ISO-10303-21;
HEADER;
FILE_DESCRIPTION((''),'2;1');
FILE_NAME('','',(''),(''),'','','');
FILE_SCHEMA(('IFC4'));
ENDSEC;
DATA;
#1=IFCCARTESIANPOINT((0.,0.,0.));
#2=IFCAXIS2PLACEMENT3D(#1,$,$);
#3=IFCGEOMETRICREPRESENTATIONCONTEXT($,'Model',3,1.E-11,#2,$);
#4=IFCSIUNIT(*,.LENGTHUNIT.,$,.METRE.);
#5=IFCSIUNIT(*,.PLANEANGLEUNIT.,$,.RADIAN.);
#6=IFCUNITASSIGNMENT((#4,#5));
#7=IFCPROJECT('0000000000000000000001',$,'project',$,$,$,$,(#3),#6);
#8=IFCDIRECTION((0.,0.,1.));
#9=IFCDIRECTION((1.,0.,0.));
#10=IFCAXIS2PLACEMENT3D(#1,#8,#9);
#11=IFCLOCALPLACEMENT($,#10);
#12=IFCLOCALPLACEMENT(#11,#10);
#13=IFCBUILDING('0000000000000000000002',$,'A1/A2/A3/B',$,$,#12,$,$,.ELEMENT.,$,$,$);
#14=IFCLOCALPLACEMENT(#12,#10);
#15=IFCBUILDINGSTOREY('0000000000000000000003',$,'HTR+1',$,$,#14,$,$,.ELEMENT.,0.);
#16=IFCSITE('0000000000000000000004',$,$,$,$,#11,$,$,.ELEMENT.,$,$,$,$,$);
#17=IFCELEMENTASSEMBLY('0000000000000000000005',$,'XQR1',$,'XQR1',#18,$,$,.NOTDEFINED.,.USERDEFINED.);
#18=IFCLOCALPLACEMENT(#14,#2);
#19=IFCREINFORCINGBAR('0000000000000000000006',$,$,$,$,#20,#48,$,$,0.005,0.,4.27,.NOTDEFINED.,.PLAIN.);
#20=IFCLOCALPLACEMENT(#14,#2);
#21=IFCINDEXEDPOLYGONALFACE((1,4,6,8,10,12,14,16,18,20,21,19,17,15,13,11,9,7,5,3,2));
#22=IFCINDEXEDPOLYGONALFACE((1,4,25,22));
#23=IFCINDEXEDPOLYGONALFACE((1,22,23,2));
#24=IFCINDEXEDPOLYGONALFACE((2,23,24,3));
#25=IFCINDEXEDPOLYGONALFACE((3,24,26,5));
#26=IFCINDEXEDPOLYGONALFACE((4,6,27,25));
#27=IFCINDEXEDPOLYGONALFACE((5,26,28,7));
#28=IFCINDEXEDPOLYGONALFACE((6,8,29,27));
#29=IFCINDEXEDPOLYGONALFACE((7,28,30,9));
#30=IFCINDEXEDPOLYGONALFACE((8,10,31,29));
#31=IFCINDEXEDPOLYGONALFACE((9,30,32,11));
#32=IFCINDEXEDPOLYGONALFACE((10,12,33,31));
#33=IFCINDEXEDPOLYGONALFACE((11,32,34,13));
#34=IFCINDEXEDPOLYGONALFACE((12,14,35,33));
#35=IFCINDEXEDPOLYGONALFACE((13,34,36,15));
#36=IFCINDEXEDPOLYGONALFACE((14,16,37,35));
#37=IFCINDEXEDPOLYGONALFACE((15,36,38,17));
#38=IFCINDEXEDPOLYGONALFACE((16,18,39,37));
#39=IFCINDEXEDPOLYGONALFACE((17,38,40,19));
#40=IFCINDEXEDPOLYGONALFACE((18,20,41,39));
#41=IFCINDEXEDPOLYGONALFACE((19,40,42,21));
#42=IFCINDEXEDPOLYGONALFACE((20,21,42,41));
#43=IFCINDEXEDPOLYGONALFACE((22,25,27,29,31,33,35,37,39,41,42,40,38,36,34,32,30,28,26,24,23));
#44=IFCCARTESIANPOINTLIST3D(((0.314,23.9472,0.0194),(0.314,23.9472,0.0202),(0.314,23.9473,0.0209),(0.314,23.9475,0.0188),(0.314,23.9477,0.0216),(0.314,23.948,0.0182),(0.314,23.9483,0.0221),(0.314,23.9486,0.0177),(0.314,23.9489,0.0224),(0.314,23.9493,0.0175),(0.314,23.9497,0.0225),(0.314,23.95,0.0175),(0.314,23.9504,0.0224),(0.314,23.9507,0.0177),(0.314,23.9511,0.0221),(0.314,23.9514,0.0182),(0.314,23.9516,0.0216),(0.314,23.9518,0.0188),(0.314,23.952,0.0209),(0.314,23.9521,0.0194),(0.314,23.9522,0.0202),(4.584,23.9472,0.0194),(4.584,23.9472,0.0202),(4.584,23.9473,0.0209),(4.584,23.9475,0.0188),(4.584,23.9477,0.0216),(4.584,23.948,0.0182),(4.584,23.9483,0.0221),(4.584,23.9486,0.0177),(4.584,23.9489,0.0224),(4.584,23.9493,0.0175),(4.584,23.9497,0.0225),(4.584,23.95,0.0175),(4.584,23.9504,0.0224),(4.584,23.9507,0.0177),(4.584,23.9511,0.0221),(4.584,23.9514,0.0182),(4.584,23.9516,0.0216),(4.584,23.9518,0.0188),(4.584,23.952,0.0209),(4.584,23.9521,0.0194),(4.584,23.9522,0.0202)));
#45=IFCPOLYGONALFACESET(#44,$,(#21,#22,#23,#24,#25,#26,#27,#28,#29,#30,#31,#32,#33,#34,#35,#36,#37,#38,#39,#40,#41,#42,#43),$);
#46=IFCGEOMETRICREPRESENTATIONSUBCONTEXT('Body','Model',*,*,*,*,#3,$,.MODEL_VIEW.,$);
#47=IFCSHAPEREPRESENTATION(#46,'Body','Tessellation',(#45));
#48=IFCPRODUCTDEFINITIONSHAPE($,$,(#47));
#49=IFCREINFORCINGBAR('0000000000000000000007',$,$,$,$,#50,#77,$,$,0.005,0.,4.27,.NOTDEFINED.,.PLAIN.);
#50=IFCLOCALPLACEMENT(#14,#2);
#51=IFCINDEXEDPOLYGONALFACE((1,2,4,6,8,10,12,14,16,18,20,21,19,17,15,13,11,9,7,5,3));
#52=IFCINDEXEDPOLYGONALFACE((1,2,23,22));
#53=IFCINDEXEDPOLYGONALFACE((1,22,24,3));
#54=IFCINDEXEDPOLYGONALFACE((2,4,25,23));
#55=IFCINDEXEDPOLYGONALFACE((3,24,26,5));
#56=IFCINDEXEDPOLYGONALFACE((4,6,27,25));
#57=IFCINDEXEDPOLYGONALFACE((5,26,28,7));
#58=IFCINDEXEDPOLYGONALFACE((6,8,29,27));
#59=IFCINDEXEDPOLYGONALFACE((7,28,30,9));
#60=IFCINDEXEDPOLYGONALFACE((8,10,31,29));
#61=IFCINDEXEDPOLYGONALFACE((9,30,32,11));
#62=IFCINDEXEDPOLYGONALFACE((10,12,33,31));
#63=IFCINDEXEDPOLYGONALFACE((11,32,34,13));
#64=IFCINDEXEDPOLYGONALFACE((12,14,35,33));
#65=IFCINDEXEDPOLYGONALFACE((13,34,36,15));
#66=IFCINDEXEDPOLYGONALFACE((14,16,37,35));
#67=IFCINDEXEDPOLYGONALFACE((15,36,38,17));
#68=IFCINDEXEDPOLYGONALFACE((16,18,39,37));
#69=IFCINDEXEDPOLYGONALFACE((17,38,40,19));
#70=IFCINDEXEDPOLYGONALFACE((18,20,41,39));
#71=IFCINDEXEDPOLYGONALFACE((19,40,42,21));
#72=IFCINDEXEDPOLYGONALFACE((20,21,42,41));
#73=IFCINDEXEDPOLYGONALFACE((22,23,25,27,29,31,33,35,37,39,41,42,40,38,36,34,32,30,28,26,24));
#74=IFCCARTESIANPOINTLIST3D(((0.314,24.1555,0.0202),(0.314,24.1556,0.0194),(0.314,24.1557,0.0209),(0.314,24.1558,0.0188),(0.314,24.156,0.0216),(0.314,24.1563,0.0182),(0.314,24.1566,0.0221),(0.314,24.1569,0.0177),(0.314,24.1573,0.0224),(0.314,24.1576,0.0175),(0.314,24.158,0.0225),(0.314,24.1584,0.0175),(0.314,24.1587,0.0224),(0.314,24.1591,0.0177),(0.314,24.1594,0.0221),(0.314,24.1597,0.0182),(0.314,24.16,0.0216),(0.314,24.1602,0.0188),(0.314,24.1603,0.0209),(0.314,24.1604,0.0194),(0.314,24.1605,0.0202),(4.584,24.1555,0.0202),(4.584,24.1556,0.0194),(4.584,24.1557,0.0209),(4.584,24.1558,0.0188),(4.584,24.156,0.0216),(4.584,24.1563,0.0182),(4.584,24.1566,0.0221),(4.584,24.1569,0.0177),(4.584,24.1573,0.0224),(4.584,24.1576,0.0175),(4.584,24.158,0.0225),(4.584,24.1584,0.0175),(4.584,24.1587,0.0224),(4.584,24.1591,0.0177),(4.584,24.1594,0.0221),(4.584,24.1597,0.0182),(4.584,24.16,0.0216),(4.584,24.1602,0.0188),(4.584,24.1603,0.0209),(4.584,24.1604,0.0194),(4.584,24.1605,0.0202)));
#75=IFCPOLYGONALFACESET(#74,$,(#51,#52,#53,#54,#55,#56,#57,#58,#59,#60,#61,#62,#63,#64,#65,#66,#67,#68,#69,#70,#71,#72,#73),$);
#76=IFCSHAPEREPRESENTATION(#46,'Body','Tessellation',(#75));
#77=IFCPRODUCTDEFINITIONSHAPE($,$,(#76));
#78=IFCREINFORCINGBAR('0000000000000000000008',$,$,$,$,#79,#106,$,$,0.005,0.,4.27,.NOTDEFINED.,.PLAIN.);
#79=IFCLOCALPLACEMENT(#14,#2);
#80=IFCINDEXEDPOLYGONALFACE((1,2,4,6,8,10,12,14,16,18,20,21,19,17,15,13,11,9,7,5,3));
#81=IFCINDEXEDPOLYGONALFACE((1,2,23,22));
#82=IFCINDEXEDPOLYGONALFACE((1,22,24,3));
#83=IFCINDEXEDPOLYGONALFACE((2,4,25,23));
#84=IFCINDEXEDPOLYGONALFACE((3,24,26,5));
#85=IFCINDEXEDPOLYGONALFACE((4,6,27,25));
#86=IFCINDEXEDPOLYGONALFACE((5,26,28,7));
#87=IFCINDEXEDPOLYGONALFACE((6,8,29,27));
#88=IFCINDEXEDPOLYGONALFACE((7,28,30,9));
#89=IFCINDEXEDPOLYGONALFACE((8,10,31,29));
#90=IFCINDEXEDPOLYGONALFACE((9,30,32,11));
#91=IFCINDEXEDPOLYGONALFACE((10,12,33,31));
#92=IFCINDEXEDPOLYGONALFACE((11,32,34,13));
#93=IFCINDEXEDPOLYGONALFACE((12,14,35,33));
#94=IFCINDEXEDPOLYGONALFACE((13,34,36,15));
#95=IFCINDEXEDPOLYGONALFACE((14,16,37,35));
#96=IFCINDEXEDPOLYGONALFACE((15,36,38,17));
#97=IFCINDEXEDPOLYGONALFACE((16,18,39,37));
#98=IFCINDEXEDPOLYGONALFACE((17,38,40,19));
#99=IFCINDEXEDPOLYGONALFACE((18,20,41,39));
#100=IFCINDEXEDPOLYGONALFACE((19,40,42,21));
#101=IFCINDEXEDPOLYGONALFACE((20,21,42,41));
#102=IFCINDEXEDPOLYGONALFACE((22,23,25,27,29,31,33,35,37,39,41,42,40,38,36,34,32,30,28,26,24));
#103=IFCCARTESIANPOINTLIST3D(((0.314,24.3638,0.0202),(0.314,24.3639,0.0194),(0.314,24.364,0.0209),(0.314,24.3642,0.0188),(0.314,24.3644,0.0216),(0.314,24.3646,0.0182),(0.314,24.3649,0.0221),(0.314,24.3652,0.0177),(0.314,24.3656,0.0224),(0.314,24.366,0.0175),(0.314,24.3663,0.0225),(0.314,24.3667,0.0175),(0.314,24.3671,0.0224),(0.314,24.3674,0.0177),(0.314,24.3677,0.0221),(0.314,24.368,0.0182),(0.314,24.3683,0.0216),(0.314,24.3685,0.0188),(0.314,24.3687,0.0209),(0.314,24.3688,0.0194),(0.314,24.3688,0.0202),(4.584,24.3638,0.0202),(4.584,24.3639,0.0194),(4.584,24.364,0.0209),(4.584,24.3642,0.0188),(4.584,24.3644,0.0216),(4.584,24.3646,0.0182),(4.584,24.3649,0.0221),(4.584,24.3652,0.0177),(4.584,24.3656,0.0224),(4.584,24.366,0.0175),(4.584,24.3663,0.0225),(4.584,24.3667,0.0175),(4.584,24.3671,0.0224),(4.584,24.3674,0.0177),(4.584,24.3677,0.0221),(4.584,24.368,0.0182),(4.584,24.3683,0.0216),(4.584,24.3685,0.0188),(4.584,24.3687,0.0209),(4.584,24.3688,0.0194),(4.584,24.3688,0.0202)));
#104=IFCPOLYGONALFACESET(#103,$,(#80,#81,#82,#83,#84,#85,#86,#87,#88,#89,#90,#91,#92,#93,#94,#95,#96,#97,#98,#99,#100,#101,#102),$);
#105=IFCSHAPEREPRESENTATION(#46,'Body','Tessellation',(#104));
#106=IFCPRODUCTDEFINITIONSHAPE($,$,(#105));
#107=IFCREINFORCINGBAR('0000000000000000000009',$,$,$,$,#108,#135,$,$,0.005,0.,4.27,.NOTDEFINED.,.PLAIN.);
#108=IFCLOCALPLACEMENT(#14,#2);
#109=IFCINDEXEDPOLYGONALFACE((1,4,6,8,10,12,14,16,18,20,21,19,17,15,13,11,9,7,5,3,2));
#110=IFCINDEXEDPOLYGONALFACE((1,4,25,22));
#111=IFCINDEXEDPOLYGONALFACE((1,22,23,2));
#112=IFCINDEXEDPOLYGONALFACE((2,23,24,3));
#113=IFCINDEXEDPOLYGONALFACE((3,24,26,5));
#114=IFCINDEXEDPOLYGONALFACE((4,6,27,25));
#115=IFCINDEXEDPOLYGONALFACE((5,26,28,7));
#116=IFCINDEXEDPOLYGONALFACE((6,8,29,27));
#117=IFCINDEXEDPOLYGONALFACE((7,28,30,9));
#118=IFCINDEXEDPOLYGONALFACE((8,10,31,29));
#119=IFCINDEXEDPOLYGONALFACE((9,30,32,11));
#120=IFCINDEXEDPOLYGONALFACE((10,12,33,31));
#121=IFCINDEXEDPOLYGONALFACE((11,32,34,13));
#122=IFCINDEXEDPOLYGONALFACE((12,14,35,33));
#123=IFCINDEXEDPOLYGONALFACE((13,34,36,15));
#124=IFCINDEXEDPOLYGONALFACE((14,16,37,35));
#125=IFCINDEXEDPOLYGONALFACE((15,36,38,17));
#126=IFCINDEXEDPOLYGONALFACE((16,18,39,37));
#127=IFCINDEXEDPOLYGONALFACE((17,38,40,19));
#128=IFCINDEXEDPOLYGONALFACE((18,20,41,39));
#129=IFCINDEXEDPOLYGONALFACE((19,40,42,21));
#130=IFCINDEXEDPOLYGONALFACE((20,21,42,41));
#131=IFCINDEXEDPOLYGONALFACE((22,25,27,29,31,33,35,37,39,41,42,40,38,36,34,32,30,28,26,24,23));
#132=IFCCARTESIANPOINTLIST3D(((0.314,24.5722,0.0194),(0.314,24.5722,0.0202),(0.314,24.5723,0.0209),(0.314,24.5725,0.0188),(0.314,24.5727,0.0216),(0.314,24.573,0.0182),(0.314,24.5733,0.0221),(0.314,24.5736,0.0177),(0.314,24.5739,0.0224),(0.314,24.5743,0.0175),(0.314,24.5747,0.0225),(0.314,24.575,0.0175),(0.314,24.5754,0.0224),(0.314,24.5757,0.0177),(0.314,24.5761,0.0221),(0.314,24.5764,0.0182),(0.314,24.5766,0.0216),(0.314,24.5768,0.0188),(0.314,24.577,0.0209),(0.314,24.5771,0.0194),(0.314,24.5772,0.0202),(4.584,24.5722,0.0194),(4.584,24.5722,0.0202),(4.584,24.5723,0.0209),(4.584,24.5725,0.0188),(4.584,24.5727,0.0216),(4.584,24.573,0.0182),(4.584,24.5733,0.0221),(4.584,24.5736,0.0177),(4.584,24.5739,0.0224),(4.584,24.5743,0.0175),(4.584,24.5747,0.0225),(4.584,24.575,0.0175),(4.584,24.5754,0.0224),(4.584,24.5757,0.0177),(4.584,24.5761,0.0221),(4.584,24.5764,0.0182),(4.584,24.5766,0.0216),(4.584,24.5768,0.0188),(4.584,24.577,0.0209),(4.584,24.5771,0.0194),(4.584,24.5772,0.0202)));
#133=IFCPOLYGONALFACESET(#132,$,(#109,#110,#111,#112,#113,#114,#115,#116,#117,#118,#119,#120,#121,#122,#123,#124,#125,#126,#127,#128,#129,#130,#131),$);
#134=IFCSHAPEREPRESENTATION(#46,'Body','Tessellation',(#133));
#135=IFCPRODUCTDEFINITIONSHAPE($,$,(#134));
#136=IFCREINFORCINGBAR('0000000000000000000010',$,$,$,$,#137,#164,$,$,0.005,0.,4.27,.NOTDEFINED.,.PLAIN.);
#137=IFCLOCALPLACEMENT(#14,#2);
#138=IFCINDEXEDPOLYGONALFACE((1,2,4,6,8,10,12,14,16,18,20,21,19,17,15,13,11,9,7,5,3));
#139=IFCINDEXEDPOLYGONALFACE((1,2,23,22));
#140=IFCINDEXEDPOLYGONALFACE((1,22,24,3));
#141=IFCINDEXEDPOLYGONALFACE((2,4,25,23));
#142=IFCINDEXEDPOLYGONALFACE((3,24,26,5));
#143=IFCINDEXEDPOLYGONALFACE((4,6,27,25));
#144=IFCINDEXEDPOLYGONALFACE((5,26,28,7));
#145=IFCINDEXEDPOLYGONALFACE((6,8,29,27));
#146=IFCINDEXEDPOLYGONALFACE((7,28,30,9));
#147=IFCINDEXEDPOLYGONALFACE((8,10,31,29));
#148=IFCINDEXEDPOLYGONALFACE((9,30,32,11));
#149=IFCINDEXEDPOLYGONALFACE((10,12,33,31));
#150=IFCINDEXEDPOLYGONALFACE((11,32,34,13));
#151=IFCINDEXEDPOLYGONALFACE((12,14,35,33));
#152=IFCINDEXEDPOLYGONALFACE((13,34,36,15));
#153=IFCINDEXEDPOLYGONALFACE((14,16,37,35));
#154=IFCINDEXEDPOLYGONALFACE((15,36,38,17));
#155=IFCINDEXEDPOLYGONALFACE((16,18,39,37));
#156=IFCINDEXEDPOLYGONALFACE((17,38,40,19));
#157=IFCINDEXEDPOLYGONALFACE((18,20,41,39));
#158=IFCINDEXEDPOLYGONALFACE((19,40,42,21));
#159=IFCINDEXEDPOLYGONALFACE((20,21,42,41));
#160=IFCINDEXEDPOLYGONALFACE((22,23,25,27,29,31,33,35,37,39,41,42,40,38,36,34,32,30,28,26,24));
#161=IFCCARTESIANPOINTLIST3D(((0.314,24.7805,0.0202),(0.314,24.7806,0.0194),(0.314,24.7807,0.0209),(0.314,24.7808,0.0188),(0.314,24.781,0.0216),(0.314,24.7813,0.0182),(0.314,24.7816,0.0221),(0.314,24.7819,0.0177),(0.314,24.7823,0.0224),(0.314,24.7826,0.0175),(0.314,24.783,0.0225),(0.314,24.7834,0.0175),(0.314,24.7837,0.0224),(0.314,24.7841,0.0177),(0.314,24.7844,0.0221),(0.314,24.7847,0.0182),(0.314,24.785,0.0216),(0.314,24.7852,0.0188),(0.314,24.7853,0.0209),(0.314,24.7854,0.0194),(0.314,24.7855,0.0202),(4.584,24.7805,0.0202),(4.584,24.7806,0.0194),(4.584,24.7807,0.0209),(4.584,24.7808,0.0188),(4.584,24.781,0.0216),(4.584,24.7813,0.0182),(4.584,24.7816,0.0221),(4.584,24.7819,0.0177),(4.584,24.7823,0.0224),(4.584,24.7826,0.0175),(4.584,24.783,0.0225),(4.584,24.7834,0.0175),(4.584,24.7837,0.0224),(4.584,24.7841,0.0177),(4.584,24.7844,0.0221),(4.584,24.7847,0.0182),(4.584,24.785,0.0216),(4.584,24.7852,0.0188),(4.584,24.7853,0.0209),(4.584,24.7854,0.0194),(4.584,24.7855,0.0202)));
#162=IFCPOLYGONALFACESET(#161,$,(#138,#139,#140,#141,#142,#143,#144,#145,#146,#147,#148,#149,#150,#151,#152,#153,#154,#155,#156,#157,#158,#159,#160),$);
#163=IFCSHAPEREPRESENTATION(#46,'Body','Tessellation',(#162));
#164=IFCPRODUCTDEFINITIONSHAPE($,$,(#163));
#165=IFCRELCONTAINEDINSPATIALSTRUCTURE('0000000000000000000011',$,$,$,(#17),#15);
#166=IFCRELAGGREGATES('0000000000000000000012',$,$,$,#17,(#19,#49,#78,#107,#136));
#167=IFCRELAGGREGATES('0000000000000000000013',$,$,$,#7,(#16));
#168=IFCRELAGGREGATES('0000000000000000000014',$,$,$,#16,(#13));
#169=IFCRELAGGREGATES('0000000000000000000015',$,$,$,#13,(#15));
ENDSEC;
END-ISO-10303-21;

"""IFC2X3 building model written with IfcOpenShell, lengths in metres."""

from ifc_helpers import new_model, entity, si_unit, origin, origin_with_axes, place, context, subcontext, project, spatial, shape, element, aggregate, save


model = new_model("IFC2X3")

# Units and contexts
model_context = context("Model", 3, precision=1e-11, world=origin())
body_context = subcontext(model_context, "Body", "Model", "MODEL_VIEW")
ifc_project = project(units=[si_unit("LENGTHUNIT", "METRE"), si_unit("PLANEANGLEUNIT", "RADIAN")], contexts=[model_context])

# Site, building, storey
site_placement = place(None, origin_with_axes())
site = spatial("IfcSite", under=ifc_project, at=site_placement, CompositionType="ELEMENT")
building_placement = place(site_placement, origin_with_axes())
building = spatial("IfcBuilding", under=site, at=building_placement, Name="A1/A2/A3/B", CompositionType="ELEMENT")
storey_placement = place(building_placement, origin_with_axes())
storey = spatial("IfcBuildingStorey", under=building, at=storey_placement, Name="HTR+1", CompositionType="ELEMENT", Elevation=0.0)

# Element assembly, reinforcing bars
assembly_1_placement = place(storey_placement, origin_with_axes())
assembly_1 = element("IfcElementAssembly", 1, at=assembly_1_placement, inside=storey, Name="XQR1", ObjectType="XQR1", AssemblyPlace="NOTDEFINED", PredefinedType="USERDEFINED")
reinforcing_bar_1_placement = place(assembly_1_placement, origin_with_axes())
reinforcing_bar_1 = element("IfcReinforcingBar", 2, at=reinforcing_bar_1_placement, BarLength=4.27, BarRole="NOTDEFINED", BarSurface="PLAIN", CrossSectionArea=0.0, NominalDiameter=0.005, shapes=[
    shape(body_context, "Body", "AdvancedSweptSolid", [entity("IfcSweptDiskSolid", entity("IfcPolyline", [entity("IfcCartesianPoint", [0.314, 23.9497, 0.02]), entity("IfcCartesianPoint", [4.584, 23.9497, 0.02])]), 0.0025, None, 0.0, 4.27)]),
    shape(body_context, "Body", "AdvancedSweptSolid", [entity("IfcSweptDiskSolid", entity("IfcPolyline", [entity("IfcCartesianPoint", [0.314, 23.9497, 0.02]), entity("IfcCartesianPoint", [4.584, 23.9497, 0.02])]), 0.0025, None, 0.0, 4.27)]),
])
reinforcing_bar_2_placement = place(assembly_1_placement, origin_with_axes())
reinforcing_bar_2 = element("IfcReinforcingBar", 3, at=reinforcing_bar_2_placement, BarLength=4.27, BarRole="NOTDEFINED", BarSurface="PLAIN", CrossSectionArea=0.0, NominalDiameter=0.005, shapes=[
    shape(body_context, "Body", "AdvancedSweptSolid", [entity("IfcSweptDiskSolid", entity("IfcPolyline", [entity("IfcCartesianPoint", [0.314, 24.158, 0.02]), entity("IfcCartesianPoint", [4.584, 24.158, 0.02])]), 0.0025, None, 0.0, 4.27)]),
    shape(body_context, "Body", "AdvancedSweptSolid", [entity("IfcSweptDiskSolid", entity("IfcPolyline", [entity("IfcCartesianPoint", [0.314, 24.158, 0.02]), entity("IfcCartesianPoint", [4.584, 24.158, 0.02])]), 0.0025, None, 0.0, 4.27)]),
])
reinforcing_bar_3_placement = place(assembly_1_placement, origin_with_axes())
reinforcing_bar_3 = element("IfcReinforcingBar", 4, at=reinforcing_bar_3_placement, BarLength=4.27, BarRole="NOTDEFINED", BarSurface="PLAIN", CrossSectionArea=0.0, NominalDiameter=0.005, shapes=[
    shape(body_context, "Body", "AdvancedSweptSolid", [entity("IfcSweptDiskSolid", entity("IfcPolyline", [entity("IfcCartesianPoint", [0.314, 24.3663, 0.02]), entity("IfcCartesianPoint", [4.584, 24.3663, 0.02])]), 0.0025, None, 0.0, 4.27)]),
    shape(body_context, "Body", "AdvancedSweptSolid", [entity("IfcSweptDiskSolid", entity("IfcPolyline", [entity("IfcCartesianPoint", [0.314, 24.3663, 0.02]), entity("IfcCartesianPoint", [4.584, 24.3663, 0.02])]), 0.0025, None, 0.0, 4.27)]),
])
reinforcing_bar_4_placement = place(assembly_1_placement, origin_with_axes())
reinforcing_bar_4 = element("IfcReinforcingBar", 5, at=reinforcing_bar_4_placement, BarLength=4.27, BarRole="NOTDEFINED", BarSurface="PLAIN", CrossSectionArea=0.0, NominalDiameter=0.005, shapes=[
    shape(body_context, "Body", "AdvancedSweptSolid", [entity("IfcSweptDiskSolid", entity("IfcPolyline", [entity("IfcCartesianPoint", [0.314, 24.5747, 0.02]), entity("IfcCartesianPoint", [4.584, 24.5747, 0.02])]), 0.0025, None, 0.0, 4.27)]),
    shape(body_context, "Body", "AdvancedSweptSolid", [entity("IfcSweptDiskSolid", entity("IfcPolyline", [entity("IfcCartesianPoint", [0.314, 24.5747, 0.02]), entity("IfcCartesianPoint", [4.584, 24.5747, 0.02])]), 0.0025, None, 0.0, 4.27)]),
])
reinforcing_bar_5_placement = place(assembly_1_placement, origin_with_axes())
reinforcing_bar_5 = element("IfcReinforcingBar", 6, at=reinforcing_bar_5_placement, BarLength=4.27, BarRole="NOTDEFINED", BarSurface="PLAIN", CrossSectionArea=0.0, NominalDiameter=0.005, shapes=[
    shape(body_context, "Body", "AdvancedSweptSolid", [entity("IfcSweptDiskSolid", entity("IfcPolyline", [entity("IfcCartesianPoint", [0.314, 24.783, 0.02]), entity("IfcCartesianPoint", [4.584, 24.783, 0.02])]), 0.0025, None, 0.0, 4.27)]),
    shape(body_context, "Body", "AdvancedSweptSolid", [entity("IfcSweptDiskSolid", entity("IfcPolyline", [entity("IfcCartesianPoint", [0.314, 24.783, 0.02]), entity("IfcCartesianPoint", [4.584, 24.783, 0.02])]), 0.0025, None, 0.0, 4.27)]),
])
aggregate(assembly_1, [reinforcing_bar_1, reinforcing_bar_2, reinforcing_bar_3, reinforcing_bar_4, reinforcing_bar_5])

save(model, "model.ifc")
